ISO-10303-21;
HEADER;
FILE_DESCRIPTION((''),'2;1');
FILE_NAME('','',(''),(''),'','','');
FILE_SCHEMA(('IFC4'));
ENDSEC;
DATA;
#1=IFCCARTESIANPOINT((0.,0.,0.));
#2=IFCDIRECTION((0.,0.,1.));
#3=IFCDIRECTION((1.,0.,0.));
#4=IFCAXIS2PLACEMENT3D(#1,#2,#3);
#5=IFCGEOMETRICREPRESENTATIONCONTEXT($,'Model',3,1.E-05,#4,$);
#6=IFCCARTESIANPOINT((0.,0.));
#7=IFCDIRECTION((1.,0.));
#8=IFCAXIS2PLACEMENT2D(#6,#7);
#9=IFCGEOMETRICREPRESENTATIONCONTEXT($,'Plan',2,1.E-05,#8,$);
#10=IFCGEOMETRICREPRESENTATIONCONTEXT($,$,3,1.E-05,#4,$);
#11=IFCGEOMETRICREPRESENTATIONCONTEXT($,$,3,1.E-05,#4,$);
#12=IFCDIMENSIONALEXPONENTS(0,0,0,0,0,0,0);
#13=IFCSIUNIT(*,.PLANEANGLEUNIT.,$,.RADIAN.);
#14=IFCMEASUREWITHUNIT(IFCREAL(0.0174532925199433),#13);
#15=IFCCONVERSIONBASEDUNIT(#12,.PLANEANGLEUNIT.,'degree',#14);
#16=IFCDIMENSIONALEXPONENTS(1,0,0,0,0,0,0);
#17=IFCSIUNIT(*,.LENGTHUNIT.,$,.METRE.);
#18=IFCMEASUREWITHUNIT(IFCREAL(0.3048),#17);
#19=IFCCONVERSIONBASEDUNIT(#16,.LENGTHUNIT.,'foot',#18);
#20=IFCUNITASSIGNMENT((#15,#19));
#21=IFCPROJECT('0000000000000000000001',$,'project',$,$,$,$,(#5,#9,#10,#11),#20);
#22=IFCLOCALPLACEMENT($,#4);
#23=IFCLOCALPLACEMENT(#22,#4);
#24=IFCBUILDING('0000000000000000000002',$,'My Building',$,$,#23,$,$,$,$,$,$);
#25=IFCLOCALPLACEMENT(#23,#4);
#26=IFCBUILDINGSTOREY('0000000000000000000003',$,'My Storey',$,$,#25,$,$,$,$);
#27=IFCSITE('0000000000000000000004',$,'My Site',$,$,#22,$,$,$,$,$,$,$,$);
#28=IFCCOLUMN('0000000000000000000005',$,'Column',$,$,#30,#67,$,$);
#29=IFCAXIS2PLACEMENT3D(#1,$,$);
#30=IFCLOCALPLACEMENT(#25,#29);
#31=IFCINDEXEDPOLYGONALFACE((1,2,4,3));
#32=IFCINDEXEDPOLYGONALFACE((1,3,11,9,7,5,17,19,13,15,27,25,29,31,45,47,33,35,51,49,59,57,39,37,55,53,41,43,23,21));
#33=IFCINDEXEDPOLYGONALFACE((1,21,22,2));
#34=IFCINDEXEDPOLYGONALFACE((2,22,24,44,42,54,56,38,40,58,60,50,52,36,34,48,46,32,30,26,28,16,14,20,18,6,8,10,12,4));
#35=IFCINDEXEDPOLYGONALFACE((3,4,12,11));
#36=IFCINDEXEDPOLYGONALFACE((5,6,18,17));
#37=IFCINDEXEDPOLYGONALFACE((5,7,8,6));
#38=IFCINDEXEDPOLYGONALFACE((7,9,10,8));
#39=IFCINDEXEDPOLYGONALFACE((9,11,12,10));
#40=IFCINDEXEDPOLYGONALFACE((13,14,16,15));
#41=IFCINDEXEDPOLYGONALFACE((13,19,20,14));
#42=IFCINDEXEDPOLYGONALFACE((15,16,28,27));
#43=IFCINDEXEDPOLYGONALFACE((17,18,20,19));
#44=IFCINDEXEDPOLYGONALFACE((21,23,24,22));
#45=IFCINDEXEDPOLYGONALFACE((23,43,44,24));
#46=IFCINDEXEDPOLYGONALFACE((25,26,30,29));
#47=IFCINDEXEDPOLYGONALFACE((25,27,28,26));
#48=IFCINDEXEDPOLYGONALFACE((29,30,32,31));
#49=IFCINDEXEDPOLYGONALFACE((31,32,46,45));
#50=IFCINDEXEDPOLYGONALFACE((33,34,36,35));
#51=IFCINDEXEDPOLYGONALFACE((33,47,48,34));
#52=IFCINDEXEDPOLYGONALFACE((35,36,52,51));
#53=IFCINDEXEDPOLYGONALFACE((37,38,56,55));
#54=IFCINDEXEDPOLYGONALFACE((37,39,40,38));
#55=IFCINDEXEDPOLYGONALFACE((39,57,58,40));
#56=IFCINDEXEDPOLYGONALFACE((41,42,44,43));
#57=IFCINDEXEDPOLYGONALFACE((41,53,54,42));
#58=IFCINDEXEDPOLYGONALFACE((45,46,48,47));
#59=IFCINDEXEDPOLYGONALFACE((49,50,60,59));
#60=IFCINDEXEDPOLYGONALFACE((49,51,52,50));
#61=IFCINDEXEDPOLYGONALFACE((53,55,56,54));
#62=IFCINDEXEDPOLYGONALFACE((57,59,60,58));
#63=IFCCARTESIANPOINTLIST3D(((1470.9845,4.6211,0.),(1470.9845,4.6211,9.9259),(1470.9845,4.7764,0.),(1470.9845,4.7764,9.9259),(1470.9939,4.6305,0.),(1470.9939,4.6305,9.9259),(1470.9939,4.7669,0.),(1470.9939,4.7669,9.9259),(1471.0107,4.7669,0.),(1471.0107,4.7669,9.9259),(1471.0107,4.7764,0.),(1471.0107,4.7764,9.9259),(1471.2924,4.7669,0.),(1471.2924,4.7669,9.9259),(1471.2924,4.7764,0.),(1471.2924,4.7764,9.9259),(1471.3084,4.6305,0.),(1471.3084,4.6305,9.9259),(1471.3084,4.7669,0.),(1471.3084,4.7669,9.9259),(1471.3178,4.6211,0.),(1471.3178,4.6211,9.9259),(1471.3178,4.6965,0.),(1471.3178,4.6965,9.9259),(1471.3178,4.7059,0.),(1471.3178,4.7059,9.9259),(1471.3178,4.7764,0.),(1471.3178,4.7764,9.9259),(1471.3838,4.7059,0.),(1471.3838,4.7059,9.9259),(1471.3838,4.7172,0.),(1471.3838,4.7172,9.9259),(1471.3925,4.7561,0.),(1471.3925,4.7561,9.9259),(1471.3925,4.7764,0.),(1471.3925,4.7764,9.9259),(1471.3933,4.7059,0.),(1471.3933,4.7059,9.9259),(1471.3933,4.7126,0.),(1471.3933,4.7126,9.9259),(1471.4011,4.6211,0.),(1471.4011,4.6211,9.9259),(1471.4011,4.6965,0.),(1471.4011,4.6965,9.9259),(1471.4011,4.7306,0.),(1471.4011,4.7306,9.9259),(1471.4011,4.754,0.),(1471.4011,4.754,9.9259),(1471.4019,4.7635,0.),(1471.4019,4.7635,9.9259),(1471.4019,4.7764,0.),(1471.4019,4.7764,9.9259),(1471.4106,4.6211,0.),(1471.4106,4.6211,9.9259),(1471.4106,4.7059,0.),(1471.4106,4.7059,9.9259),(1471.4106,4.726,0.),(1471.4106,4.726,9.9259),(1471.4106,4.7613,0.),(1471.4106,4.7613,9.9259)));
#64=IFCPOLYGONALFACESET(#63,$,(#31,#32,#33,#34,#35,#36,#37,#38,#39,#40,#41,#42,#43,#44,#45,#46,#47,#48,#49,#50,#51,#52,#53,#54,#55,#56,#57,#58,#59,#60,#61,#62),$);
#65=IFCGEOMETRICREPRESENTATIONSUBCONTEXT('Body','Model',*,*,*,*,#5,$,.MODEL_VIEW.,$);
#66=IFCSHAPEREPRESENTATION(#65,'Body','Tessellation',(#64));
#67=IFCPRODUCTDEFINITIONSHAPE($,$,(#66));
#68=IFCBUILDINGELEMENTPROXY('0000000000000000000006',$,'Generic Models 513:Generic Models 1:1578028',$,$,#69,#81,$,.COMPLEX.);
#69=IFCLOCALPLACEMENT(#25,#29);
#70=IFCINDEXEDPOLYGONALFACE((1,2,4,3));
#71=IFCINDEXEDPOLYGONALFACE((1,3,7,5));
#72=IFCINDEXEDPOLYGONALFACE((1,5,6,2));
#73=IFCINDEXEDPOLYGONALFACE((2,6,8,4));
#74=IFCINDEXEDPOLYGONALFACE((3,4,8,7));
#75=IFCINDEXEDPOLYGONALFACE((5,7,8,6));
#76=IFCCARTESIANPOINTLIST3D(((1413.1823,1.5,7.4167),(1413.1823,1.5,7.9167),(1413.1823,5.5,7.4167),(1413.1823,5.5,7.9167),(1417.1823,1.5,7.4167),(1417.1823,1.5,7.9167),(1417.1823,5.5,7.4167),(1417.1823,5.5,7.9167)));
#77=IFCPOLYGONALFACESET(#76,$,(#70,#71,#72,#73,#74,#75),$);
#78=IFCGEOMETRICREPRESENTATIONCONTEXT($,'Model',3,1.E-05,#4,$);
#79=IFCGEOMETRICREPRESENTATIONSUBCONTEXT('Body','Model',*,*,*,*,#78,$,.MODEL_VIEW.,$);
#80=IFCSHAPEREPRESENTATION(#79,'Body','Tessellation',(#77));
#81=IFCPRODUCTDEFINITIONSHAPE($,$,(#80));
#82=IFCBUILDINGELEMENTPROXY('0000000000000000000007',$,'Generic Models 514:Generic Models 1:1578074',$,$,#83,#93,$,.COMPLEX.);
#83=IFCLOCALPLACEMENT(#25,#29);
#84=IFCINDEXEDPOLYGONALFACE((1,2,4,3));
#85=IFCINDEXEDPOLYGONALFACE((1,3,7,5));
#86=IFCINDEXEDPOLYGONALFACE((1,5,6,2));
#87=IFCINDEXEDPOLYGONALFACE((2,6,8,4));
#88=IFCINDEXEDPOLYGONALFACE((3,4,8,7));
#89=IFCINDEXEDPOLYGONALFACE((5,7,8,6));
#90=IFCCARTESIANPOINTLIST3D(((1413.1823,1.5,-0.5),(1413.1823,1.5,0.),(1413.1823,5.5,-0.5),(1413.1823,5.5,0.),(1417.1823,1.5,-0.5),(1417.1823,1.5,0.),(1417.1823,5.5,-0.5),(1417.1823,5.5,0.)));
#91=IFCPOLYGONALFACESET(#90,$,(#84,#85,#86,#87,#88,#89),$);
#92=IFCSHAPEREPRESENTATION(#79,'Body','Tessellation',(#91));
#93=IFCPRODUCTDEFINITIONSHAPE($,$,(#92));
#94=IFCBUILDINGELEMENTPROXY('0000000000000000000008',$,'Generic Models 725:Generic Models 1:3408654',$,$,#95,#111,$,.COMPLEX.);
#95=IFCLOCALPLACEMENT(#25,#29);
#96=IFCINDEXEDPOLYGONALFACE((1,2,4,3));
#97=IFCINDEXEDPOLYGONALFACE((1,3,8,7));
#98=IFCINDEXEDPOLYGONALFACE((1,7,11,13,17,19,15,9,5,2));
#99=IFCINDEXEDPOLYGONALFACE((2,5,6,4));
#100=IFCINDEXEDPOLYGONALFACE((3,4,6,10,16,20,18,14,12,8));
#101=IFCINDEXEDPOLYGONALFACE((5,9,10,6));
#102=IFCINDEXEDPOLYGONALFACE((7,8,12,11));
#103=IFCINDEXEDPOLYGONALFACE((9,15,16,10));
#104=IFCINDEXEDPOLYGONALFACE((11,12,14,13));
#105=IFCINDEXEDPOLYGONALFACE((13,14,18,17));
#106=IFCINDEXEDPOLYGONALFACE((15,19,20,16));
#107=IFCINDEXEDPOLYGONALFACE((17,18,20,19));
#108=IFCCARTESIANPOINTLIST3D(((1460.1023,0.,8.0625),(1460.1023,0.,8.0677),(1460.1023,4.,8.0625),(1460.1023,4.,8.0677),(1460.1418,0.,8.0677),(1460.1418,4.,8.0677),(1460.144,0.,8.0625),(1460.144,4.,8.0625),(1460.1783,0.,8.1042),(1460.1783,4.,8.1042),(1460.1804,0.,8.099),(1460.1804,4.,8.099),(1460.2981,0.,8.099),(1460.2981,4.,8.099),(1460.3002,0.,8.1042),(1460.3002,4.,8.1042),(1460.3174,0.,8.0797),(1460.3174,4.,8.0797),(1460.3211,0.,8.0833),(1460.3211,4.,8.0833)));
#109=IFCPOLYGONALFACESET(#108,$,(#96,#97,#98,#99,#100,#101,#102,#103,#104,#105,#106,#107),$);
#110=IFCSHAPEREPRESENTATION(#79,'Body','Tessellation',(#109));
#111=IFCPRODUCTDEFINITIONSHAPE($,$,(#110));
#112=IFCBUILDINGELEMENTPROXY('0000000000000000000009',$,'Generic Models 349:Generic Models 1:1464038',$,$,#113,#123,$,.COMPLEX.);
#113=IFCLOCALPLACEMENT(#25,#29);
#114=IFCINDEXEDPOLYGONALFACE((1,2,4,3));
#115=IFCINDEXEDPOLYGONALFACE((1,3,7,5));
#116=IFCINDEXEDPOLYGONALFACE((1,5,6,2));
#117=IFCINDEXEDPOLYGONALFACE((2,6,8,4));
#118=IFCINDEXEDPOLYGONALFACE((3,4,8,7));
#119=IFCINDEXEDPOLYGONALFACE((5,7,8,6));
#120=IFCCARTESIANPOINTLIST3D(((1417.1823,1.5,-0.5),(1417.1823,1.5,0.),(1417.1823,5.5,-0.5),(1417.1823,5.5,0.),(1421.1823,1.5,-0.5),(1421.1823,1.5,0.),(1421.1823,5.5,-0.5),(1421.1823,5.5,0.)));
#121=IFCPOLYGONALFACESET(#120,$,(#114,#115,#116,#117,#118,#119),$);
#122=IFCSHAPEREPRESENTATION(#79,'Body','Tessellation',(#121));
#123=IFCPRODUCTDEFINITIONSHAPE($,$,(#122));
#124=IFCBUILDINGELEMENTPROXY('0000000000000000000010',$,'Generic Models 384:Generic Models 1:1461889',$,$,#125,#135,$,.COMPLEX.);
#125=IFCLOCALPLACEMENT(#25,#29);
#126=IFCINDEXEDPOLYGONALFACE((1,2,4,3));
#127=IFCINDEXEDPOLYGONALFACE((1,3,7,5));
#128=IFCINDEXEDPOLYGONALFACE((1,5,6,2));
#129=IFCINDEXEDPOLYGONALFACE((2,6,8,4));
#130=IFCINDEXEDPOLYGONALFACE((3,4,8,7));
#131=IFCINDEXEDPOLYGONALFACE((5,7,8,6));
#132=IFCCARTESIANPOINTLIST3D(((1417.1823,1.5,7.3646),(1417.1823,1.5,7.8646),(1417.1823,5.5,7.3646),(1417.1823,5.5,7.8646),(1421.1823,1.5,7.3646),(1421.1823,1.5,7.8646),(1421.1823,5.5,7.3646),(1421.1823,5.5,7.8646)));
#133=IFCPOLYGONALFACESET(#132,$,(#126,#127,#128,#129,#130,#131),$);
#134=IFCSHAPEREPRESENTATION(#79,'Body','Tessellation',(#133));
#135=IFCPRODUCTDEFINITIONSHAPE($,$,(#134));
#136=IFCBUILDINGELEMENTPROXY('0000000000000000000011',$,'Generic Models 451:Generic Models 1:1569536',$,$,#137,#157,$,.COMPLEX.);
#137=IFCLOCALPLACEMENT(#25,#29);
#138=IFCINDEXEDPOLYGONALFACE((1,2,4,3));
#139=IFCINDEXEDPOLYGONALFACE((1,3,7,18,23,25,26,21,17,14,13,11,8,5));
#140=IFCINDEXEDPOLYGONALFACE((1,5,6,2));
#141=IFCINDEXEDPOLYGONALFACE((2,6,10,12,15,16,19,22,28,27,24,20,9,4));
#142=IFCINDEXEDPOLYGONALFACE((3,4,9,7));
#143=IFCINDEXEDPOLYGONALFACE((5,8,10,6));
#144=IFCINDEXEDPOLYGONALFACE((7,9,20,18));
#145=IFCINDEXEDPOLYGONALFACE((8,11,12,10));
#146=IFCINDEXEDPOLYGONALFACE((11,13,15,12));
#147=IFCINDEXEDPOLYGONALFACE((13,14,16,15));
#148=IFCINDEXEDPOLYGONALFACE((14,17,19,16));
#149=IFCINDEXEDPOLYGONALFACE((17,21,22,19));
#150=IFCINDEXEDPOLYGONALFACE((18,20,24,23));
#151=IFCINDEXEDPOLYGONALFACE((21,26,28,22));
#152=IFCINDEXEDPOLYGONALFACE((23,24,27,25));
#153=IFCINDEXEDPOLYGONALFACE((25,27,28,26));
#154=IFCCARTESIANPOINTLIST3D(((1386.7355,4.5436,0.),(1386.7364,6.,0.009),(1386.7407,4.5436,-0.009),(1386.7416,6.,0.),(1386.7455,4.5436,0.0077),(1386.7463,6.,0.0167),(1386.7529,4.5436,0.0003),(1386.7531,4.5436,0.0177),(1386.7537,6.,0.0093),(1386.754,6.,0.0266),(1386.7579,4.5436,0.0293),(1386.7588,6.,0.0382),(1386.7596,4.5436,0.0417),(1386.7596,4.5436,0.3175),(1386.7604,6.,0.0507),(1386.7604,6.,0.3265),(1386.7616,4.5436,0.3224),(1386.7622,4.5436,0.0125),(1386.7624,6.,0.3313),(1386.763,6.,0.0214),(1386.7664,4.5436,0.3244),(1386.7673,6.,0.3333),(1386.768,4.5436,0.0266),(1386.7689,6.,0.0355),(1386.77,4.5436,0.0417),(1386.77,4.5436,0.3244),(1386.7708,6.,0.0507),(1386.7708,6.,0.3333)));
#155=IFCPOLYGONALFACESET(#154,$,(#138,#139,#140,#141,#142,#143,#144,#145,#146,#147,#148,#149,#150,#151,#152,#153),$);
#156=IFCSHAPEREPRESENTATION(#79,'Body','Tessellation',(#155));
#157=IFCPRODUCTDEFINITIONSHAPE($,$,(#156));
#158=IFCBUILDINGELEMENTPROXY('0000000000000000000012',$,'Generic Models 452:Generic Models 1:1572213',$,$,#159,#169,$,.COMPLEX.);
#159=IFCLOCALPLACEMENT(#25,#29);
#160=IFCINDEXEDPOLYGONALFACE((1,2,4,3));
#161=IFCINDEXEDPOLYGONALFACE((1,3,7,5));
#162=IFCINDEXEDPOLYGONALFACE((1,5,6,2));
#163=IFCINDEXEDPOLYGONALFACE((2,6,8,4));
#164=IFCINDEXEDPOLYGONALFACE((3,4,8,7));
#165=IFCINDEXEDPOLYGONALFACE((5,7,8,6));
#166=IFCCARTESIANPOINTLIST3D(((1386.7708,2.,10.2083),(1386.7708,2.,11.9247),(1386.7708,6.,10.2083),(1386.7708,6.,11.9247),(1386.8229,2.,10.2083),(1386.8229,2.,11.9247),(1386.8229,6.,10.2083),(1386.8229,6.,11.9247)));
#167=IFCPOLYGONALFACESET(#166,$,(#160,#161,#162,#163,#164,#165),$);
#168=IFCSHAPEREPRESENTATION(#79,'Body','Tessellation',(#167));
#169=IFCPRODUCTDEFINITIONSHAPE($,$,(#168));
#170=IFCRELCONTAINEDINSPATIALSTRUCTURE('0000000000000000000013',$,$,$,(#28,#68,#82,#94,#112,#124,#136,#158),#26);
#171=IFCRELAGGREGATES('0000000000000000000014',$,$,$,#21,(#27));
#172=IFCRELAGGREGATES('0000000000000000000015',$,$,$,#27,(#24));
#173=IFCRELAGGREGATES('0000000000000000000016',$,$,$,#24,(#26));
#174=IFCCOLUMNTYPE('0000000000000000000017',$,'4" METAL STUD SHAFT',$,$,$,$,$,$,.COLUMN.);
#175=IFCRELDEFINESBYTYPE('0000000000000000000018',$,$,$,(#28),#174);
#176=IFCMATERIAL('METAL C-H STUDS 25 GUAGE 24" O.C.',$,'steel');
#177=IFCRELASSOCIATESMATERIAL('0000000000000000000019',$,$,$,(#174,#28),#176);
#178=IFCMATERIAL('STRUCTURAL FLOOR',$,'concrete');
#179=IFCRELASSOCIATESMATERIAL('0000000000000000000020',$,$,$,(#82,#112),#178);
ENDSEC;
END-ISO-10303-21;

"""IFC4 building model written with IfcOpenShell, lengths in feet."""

from ifc_helpers import new_model, entity, si_unit, converted_unit, frame, origin_with_axes, origin_2d_with_axis, place, context, subcontext, project, spatial, polyline, line, indexed_curve, outline, extrude, material, material_profile, profile_set, profile_usage, type_object, element, save


model = new_model("IFC4")

# Units and contexts
model_context_1 = context("Model", 3, precision=1e-05, world=origin_with_axes())
plan_context = context("Plan", 2, precision=1e-05, world=origin_2d_with_axis())
model_context_2 = context("Model", 3, precision=1e-05, world=origin_with_axes())
context_of_model_1 = context(None, 3, precision=1e-05, world=origin_with_axes())
context_of_model_2 = context(None, 3, precision=1e-05, world=origin_with_axes())
body_context_1 = subcontext(model_context_1, "Body", "Model", "MODEL_VIEW")
body_context_2 = subcontext(model_context_2, "Body", "Model", "MODEL_VIEW")
ifc_project = project(units=[converted_unit("PLANEANGLEUNIT", "degree", entity("IfcReal", 0.0174532925199433), si_unit("PLANEANGLEUNIT", "RADIAN"), dimensions=[0, 0, 0, 0, 0, 0, 0]), converted_unit("LENGTHUNIT", "foot", entity("IfcReal", 0.3048), si_unit("LENGTHUNIT", "METRE"), dimensions=[1, 0, 0, 0, 0, 0, 0])], contexts=[model_context_1, plan_context, context_of_model_1, context_of_model_2])

# Site, building, storey
site_placement = place(None, origin_with_axes())
site = spatial("IfcSite", under=ifc_project, at=site_placement, Name="My Site")
building_placement = place(site_placement, origin_with_axes())
building = spatial("IfcBuilding", under=site, at=building_placement, Name="My Building")
storey_placement = place(building_placement, origin_with_axes())
storey = spatial("IfcBuildingStorey", under=building, at=storey_placement, Name="My Storey")

# Column
ifc_material_1 = material(Name="METAL C-H STUDS 25 GUAGE 24\" O.C.", Category="steel")
ifc_material_profile = material_profile(ifc_material_1, outline(indexed_curve([(0.4088, 0.0849), (0.4261, 0.0849), (0.4261, 0.0), (0.4166, 0.0), (0.4166, 0.0754), (0.3333, 0.0754), (0.3333, 0.0), (0.0, 0.0), (0.0, 0.1553), (0.0262, 0.1553), (0.0262, 0.1459), (0.0094, 0.1459), (0.0094, 0.0094), (0.3239, 0.0094), (0.3239, 0.1459), (0.3079, 0.1459), (0.3079, 0.1553), (0.3333, 0.1553), (0.3333, 0.0848), (0.3993, 0.0849), (0.3993, 0.0961), (0.4166, 0.1095), (0.4166, 0.1329), (0.408, 0.1351), (0.408, 0.1553), (0.4174, 0.1553), (0.4174, 0.1424), (0.4261, 0.1403), (0.4261, 0.1049), (0.4088, 0.0915)], segments=[line(24, 23), line(23, 22), line(22, 21), line(21, 20), line(20, 19), line(19, 18), line(18, 17), line(17, 16), line(16, 15), line(15, 14), line(14, 13), line(13, 12), line(12, 11), line(11, 10), line(10, 9), line(9, 8), line(8, 7), line(7, 6), line(6, 5), line(5, 4), line(4, 3), line(3, 2), line(2, 1), line(1, 30), line(30, 29), line(29, 28), line(28, 27), line(27, 26), line(26, 25), line(25, 24)], self_intersect=False)))
ifc_profile_set = profile_set([ifc_material_profile])
ifc_profile_usage = profile_usage(ifc_profile_set)
column_type = type_object("IfcColumnType", Name="4\" METAL STUD SHAFT", PredefinedType="COLUMN", material=ifc_profile_set)
column_placement = place(storey_placement, frame((1470.9845, 4.6211, 0.0), z_axis=(0.0, 0.0, 1.0), x_axis=(1.0, 0.0, 0.0)))
element("IfcColumn", 1, at=column_placement, inside=storey, type_object=column_type, material=ifc_profile_usage, Name="Column", context=body_context_1, shape_type="SweptSolid", body=[
    extrude(outline(indexed_curve([(0.4088, 0.0849), (0.4261, 0.0849), (0.4261, 0.0), (0.4166, 0.0), (0.4166, 0.0754), (0.3333, 0.0754), (0.3333, 0.0), (0.0, 0.0), (0.0, 0.1553), (0.0262, 0.1553), (0.0262, 0.1459), (0.0094, 0.1459), (0.0094, 0.0094), (0.3239, 0.0094), (0.3239, 0.1459), (0.3079, 0.1459), (0.3079, 0.1553), (0.3333, 0.1553), (0.3333, 0.0848), (0.3993, 0.0849), (0.3993, 0.0961), (0.4166, 0.1095), (0.4166, 0.1329), (0.408, 0.1351), (0.408, 0.1553), (0.4174, 0.1553), (0.4174, 0.1424), (0.4261, 0.1403), (0.4261, 0.1049), (0.4088, 0.0915)], segments=[line(24, 23), line(23, 22), line(22, 21), line(21, 20), line(20, 19), line(19, 18), line(18, 17), line(17, 16), line(16, 15), line(15, 14), line(14, 13), line(13, 12), line(12, 11), line(11, 10), line(10, 9), line(9, 8), line(8, 7), line(7, 6), line(6, 5), line(5, 4), line(4, 3), line(3, 2), line(2, 1), line(1, 30), line(30, 29), line(29, 28), line(28, 27), line(27, 26), line(26, 25), line(25, 24)], self_intersect=False)), origin_with_axes(), (0.0, 0.0, 1.0), 9.9259),
])

# Building element proxies
proxy_1_placement = place(storey_placement, frame((1413.1823, 5.5, 7.4167), z_axis=(0.0, -1.0, 0.0), x_axis=(0.0, 0.0, 1.0)))
element("IfcBuildingElementProxy", 2, at=proxy_1_placement, inside=storey, Name="Generic Models 513:Generic Models 1:1578028", PredefinedType="COMPLEX", context=body_context_2, shape_type="SweptSolid", body=[
    extrude(outline(polyline([(-0.25, -2.0), (0.25, -2.0), (0.25, 2.0), (-0.25, 2.0), (-0.25, -2.0)])), frame((0.25, -2.0, 0.0), z_axis=(0.0, 0.0, -1.0), x_axis=(1.0, 0.0, 0.0)), (0.0, 0.0, -1.0), 4.0),
])
ifc_material_2 = material(Name="STRUCTURAL FLOOR", Category="concrete")
proxy_2_placement = place(storey_placement, frame((1413.1823, 5.5, -0.5), z_axis=(0.0, -1.0, 0.0), x_axis=(0.0, 0.0, 1.0)))
element("IfcBuildingElementProxy", 3, at=proxy_2_placement, inside=storey, material=ifc_material_2, Name="Generic Models 514:Generic Models 1:1578074", PredefinedType="COMPLEX", context=body_context_2, shape_type="SweptSolid", body=[
    extrude(outline(polyline([(-0.25, -2.0), (0.25, -2.0), (0.25, 2.0), (-0.25, 2.0), (-0.25, -2.0)])), frame((0.25, -2.0, 0.0), z_axis=(0.0, 0.0, -1.0), x_axis=(1.0, 0.0, 0.0)), (0.0, 0.0, -1.0), 4.0),
])
proxy_3_placement = place(storey_placement, frame((1460.1023, 4.0, 8.0625), z_axis=(0.0, -1.0, 0.0), x_axis=(0.0, 0.0, 1.0)))
element("IfcBuildingElementProxy", 4, at=proxy_3_placement, inside=storey, Name="Generic Models 725:Generic Models 1:3408654", PredefinedType="COMPLEX", context=body_context_2, shape_type="SweptSolid", body=[
    extrude(outline(polyline([(0.1082, 0.0), (0.1072, 0.0051), (0.0684, -0.0024), (0.0258, 0.0266), (-0.094, 0.0035), (-0.1105, -0.0209), (-0.1062, -0.0238), (-0.0909, -0.0012), (0.0246, 0.021), (0.0673, -0.0079), (0.1082, 0.0)])), frame((0.0205, -0.1063, 0.0), z_axis=(0.0, 0.0, -1.0), x_axis=(-0.189091, 0.98196, 0.0)), (0.0, 0.0, -1.0), 4.0),
])
proxy_4_placement = place(storey_placement, frame((1417.1823, 5.5, -0.5), z_axis=(0.0, -1.0, 0.0), x_axis=(0.0, 0.0, 1.0)))
element("IfcBuildingElementProxy", 5, at=proxy_4_placement, inside=storey, material=ifc_material_2, Name="Generic Models 349:Generic Models 1:1464038", PredefinedType="COMPLEX", context=body_context_2, shape_type="SweptSolid", body=[
    extrude(outline(polyline([(-0.25, -2.0), (0.25, -2.0), (0.25, 2.0), (-0.25, 2.0), (-0.25, -2.0)])), frame((0.25, -2.0, 0.0), z_axis=(0.0, 0.0, -1.0), x_axis=(1.0, 0.0, 0.0)), (0.0, 0.0, -1.0), 4.0),
])
proxy_5_placement = place(storey_placement, frame((1417.1823, 5.5, 7.3646), z_axis=(0.0, -1.0, 0.0), x_axis=(0.0, 0.0, 1.0)))
element("IfcBuildingElementProxy", 6, at=proxy_5_placement, inside=storey, Name="Generic Models 384:Generic Models 1:1461889", PredefinedType="COMPLEX", context=body_context_2, shape_type="SweptSolid", body=[
    extrude(outline(polyline([(-0.25, -2.0), (0.25, -2.0), (0.25, 2.0), (-0.25, 2.0), (-0.25, -2.0)])), frame((0.25, -2.0, 0.0), z_axis=(0.0, 0.0, -1.0), x_axis=(1.0, 0.0, 0.0)), (0.0, 0.0, -1.0), 4.0),
])
proxy_6_placement = place(storey_placement, frame((1386.7364, 6.0, 0.0), z_axis=(0.0, -1.0, 0.0), x_axis=(0.0, 0.0, 1.0)))
element("IfcBuildingElementProxy", 7, at=proxy_6_placement, inside=storey, Name="Generic Models 451:Generic Models 1:1569536", PredefinedType="COMPLEX", context=body_context_2, shape_type="SweptSolid", body=[
    extrude(outline(polyline([(0.0748, 0.0), (0.0624, -0.0017), (-0.2134, -0.0039), (-0.2182, -0.0059), (-0.2202, -0.0108), (-0.2202, -0.0144), (0.0625, -0.0122), (0.0776, -0.01), (0.0917, -0.0041), (0.1037, 0.0053), (0.1129, 0.0175), (0.1039, 0.0226), (0.0963, 0.0126), (0.0864, 0.0049), (0.0748, 0.0)])), frame((0.113, -0.0218, 0.0), z_axis=(0.0, 0.0, -1.0), x_axis=(-0.99997, -0.007803, 0.0)), (0.006156, 0.000628, -0.999981), 1.4564),
])
proxy_7_placement = place(storey_placement, frame((1386.7708, 6.0, 10.2083), z_axis=(0.0, -1.0, 0.0), x_axis=(0.0, 0.0, 1.0)))
element("IfcBuildingElementProxy", 8, at=proxy_7_placement, inside=storey, Name="Generic Models 452:Generic Models 1:1572213", PredefinedType="COMPLEX", context=body_context_2, shape_type="SweptSolid", body=[
    extrude(outline(polyline([(-0.026, -0.8582), (0.026, -0.8582), (0.026, 0.8582), (-0.026, 0.8582), (-0.026, -0.8582)])), frame((0.8582, -0.026, 0.0), z_axis=(0.0, 0.0, -1.0), x_axis=(0.0, 1.0, 0.0)), (0.0, 0.0, -1.0), 4.0),
])

save(model, "model.ifc")
